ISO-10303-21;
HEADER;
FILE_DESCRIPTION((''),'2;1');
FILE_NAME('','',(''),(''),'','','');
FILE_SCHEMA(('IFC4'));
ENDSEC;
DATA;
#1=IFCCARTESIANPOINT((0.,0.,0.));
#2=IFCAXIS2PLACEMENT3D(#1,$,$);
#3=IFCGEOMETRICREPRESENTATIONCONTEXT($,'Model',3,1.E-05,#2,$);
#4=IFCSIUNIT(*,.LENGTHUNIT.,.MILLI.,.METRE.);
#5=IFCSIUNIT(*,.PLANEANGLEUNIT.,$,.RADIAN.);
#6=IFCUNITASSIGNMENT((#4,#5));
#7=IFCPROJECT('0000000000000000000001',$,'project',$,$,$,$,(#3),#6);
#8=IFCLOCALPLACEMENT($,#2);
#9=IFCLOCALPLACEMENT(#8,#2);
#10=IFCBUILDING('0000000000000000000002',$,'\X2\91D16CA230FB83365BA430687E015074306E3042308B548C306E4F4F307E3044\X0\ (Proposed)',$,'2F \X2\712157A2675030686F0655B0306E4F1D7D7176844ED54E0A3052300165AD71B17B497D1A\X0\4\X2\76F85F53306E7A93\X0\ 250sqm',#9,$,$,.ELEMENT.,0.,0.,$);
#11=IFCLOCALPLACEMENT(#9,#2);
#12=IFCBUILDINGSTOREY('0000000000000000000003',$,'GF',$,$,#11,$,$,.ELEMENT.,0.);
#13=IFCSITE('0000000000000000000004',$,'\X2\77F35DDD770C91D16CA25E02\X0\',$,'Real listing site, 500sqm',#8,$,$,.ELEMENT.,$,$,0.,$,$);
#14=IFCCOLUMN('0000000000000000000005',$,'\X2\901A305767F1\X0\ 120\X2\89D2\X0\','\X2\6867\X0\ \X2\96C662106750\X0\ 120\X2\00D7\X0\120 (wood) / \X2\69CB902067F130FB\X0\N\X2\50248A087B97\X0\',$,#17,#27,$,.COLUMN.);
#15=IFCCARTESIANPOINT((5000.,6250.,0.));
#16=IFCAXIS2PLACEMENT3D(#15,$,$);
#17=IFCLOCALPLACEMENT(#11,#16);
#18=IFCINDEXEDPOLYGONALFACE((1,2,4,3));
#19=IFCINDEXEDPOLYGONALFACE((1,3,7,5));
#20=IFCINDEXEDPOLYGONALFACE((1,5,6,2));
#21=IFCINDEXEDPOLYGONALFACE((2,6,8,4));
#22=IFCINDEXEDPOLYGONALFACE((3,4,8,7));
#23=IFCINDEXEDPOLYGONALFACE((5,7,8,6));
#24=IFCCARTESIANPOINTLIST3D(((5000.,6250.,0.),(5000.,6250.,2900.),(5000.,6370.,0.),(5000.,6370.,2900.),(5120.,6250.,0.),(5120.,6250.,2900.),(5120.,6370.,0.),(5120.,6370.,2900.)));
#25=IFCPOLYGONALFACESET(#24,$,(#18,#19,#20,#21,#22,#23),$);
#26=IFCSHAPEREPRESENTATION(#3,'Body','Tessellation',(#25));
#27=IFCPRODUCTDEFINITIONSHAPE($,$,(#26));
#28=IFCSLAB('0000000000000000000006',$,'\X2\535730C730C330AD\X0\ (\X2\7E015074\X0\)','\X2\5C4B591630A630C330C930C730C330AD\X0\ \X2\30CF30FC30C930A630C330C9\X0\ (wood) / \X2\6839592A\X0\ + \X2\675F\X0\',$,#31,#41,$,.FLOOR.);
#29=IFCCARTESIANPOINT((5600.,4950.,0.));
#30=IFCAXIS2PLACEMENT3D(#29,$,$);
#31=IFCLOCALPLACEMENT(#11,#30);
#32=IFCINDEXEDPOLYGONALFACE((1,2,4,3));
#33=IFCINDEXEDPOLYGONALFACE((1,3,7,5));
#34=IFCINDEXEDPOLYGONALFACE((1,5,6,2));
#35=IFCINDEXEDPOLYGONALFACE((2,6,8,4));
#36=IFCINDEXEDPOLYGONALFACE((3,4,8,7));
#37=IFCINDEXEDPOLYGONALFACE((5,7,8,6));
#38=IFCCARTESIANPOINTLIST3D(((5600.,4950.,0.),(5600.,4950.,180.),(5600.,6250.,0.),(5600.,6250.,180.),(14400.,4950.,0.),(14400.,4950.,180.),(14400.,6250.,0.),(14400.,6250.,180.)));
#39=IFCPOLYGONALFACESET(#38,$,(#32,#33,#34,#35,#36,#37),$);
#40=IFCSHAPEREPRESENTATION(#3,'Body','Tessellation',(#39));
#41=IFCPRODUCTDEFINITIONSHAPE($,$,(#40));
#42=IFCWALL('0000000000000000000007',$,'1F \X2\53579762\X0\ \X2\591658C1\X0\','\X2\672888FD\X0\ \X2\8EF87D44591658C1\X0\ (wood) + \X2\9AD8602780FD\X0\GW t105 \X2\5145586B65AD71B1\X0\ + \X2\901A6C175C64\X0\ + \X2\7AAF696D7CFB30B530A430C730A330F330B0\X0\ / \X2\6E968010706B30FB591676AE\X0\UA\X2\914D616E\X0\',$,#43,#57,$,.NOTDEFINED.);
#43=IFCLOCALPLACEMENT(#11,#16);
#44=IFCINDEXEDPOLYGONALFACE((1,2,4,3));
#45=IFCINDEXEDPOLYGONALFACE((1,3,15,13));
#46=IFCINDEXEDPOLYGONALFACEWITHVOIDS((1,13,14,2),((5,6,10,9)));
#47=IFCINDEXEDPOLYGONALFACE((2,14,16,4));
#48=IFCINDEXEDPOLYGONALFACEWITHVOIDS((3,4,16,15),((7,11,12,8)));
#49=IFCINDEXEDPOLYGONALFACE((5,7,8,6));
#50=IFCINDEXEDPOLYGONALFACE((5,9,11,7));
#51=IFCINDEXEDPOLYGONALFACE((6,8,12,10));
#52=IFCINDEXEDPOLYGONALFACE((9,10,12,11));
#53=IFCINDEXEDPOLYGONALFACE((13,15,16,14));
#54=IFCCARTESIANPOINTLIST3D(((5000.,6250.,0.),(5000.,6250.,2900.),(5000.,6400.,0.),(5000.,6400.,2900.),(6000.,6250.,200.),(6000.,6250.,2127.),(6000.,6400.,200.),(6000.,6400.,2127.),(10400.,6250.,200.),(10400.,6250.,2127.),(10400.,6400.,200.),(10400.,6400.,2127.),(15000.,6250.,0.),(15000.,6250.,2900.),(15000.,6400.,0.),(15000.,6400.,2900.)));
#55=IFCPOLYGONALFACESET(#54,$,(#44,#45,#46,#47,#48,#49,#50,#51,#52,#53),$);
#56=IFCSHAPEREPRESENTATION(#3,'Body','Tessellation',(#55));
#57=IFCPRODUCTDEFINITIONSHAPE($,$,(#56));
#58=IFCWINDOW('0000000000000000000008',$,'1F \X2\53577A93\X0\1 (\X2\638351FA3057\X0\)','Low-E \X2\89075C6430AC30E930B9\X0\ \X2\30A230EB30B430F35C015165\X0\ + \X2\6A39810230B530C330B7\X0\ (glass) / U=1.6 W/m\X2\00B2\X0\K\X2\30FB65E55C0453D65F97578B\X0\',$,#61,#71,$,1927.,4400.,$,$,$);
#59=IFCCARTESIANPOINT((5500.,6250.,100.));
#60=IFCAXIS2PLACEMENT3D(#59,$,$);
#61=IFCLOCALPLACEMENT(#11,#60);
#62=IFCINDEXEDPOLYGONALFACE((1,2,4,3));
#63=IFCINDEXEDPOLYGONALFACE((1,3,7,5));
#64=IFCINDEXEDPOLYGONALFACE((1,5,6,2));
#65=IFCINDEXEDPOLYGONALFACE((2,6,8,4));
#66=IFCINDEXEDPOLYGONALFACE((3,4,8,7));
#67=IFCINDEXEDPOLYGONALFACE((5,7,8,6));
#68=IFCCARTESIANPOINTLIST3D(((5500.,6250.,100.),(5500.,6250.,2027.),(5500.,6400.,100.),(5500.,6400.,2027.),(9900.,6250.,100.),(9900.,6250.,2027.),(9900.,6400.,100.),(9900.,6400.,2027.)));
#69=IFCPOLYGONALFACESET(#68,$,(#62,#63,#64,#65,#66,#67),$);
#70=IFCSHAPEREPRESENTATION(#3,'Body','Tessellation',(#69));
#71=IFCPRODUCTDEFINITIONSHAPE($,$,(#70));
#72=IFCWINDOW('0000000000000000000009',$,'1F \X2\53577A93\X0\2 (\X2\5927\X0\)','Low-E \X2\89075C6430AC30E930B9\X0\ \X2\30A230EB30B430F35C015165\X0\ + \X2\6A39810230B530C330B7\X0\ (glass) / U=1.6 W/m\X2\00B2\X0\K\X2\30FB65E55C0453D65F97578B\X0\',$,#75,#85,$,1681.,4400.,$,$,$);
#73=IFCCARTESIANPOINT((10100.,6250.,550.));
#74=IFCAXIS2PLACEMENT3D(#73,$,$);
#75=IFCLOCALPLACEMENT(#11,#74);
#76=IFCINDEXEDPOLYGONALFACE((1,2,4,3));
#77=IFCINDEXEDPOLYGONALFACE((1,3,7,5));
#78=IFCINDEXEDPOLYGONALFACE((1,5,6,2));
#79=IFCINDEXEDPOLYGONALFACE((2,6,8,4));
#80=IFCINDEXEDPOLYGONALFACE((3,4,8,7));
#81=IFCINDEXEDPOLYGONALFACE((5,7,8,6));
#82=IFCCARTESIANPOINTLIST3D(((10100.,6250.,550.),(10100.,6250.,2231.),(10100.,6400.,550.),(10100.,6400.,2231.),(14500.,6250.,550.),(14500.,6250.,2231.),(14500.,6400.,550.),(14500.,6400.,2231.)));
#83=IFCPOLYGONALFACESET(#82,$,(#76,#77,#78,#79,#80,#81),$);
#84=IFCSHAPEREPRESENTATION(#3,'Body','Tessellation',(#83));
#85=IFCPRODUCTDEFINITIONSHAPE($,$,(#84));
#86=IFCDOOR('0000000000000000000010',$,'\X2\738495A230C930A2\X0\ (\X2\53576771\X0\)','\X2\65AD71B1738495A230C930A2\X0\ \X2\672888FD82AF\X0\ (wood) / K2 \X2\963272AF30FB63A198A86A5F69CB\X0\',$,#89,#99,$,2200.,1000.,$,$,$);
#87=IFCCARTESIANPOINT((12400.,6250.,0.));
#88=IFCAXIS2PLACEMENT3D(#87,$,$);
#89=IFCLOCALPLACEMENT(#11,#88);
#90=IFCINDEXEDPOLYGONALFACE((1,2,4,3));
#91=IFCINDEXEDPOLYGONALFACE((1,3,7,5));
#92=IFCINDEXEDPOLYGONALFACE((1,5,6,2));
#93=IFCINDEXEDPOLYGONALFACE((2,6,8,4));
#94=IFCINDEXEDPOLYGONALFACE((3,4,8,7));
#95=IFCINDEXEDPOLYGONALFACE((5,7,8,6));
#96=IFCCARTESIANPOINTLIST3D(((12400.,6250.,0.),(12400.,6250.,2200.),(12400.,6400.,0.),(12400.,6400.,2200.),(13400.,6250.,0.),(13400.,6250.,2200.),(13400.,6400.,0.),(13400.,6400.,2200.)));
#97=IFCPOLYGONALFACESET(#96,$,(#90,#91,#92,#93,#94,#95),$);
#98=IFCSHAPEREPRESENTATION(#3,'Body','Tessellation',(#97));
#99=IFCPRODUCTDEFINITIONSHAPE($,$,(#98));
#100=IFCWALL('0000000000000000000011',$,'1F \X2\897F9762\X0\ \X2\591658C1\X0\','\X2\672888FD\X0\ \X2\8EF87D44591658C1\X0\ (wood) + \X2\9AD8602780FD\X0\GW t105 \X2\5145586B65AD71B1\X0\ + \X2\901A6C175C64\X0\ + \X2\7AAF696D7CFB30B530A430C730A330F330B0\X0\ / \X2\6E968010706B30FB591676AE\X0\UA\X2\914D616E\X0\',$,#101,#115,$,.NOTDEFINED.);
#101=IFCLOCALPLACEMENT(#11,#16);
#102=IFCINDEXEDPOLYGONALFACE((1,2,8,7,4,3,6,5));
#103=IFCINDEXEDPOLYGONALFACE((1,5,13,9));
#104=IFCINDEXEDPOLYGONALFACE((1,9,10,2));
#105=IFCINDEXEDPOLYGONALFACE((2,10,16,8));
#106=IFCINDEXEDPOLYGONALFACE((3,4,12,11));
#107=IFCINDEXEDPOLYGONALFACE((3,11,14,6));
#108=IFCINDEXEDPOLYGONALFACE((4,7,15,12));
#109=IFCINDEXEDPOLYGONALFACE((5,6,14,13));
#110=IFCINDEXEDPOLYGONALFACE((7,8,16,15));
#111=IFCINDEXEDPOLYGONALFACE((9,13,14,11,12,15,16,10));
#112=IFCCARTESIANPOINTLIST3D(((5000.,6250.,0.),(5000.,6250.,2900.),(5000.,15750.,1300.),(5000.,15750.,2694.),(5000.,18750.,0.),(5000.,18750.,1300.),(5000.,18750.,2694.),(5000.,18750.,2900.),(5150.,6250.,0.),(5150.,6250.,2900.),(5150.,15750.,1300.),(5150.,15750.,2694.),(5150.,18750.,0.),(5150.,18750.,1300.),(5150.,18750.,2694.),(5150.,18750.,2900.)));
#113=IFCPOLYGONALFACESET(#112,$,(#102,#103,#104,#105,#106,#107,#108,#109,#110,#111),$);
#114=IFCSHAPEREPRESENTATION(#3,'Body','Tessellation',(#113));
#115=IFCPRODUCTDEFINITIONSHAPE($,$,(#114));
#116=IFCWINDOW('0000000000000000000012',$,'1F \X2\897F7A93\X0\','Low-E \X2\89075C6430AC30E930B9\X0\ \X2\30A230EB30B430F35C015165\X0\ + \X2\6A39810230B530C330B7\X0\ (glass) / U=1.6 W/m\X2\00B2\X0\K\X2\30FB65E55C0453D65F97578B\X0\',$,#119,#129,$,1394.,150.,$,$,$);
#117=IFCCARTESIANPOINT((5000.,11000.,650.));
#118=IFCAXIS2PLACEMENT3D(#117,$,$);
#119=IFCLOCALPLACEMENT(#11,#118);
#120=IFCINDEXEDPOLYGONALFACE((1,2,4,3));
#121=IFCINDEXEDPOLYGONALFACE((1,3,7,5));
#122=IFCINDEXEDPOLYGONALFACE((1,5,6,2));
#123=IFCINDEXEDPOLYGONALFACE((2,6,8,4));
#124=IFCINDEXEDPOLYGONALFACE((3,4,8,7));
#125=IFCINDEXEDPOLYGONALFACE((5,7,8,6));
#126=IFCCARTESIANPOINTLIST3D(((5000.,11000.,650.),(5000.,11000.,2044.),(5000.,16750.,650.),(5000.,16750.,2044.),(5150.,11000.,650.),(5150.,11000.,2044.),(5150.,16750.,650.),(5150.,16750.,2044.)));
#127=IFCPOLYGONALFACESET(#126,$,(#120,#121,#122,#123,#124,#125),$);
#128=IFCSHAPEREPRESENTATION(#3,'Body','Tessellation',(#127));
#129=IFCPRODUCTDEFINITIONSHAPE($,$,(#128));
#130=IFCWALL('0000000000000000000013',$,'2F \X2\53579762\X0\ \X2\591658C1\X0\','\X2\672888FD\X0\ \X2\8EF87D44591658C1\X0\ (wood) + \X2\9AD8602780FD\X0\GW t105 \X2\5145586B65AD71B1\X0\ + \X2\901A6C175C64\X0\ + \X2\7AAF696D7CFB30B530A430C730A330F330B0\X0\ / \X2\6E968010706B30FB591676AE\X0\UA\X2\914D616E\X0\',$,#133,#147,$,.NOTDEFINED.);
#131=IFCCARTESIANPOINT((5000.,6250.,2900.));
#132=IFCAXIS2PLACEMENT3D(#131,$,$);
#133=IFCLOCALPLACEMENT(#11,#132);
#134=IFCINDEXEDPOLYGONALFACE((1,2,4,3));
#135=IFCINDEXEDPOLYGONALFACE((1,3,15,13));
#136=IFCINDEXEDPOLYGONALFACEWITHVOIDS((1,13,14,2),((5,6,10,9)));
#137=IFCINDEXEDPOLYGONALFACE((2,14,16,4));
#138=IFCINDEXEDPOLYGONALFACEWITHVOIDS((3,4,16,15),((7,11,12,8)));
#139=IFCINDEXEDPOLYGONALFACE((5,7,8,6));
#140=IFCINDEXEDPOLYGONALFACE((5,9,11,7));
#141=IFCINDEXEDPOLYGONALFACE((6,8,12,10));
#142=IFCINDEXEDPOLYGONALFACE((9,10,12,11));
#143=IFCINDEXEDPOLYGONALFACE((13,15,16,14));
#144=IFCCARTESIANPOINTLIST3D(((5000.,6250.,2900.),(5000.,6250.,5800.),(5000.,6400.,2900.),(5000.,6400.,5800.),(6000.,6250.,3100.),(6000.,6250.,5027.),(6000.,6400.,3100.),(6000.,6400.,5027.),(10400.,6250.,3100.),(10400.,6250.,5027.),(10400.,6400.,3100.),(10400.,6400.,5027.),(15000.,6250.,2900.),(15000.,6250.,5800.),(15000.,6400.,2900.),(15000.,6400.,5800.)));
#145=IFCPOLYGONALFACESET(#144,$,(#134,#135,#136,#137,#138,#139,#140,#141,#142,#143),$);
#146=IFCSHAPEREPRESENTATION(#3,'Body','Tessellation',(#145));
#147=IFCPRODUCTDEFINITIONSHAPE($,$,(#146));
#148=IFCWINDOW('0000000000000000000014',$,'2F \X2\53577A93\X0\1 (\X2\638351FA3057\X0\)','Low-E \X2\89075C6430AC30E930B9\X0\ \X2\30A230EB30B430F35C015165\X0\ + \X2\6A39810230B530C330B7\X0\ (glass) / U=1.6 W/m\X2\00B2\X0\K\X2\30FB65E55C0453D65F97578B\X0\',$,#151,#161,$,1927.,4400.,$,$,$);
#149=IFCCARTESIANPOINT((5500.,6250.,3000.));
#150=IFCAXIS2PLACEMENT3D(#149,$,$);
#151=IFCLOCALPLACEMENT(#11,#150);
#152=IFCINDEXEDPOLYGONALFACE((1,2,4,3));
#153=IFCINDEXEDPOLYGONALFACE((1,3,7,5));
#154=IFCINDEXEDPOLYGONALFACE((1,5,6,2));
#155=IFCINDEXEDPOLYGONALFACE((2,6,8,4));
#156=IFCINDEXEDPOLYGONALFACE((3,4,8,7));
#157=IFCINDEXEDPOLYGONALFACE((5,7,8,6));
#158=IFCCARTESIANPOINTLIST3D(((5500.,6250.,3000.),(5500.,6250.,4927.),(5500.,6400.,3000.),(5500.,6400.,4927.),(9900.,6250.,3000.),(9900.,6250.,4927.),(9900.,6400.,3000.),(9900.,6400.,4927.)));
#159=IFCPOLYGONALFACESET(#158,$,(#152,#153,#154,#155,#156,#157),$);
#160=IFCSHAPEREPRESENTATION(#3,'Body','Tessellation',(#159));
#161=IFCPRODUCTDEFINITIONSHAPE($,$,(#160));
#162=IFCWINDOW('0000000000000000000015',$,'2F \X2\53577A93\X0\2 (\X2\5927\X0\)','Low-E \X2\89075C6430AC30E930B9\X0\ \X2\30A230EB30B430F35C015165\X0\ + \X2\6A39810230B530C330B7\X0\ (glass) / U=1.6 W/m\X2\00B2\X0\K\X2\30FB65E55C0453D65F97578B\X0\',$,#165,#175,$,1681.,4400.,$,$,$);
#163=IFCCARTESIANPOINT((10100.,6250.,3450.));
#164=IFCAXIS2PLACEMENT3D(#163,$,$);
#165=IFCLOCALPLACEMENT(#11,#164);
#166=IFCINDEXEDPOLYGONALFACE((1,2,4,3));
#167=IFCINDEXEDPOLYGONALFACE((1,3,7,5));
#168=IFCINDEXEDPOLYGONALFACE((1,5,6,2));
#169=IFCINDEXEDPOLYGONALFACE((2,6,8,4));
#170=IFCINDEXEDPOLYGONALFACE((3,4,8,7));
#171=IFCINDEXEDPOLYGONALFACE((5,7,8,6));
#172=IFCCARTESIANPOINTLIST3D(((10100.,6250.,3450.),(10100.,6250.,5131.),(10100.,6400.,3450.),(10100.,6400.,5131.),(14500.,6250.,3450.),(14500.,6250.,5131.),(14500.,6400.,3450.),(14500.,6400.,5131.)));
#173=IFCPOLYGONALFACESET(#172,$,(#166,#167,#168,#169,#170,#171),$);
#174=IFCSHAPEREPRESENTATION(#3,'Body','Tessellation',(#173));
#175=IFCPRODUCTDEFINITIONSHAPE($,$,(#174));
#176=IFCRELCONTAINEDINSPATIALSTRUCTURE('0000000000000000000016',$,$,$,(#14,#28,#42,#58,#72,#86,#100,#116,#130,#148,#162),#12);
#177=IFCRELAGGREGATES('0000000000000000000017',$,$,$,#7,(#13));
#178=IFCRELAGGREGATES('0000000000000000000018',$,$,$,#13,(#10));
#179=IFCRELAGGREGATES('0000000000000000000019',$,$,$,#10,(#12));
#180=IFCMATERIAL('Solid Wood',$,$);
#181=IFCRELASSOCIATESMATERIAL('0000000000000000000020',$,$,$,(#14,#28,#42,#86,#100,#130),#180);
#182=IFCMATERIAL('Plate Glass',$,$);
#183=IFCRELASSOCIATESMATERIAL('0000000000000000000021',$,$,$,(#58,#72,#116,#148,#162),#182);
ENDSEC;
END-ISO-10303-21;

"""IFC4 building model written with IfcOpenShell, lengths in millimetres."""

from ifc_helpers import new_model, si_unit, frame, frame_2d, origin, place, context, project, spatial, rectangle, extrude, material, element, fill, save


model = new_model("IFC4")

# Units and contexts
model_context = context("Model", 3, precision=1e-05, world=origin())
ifc_project = project(units=[si_unit("LENGTHUNIT", "METRE", prefix="MILLI"), si_unit("PLANEANGLEUNIT", "RADIAN")], contexts=[model_context])

# Site, building, storey
site_placement = place(None, origin())
site = spatial("IfcSite", under=ifc_project, at=site_placement, Name="石川県金沢市", ObjectType="Real listing site, 500sqm", CompositionType="ELEMENT", RefElevation=0.0)
building_placement = place(site_placement, origin())
building = spatial("IfcBuilding", under=site, at=building_placement, Name="金沢・茶室と縁側のある和の住まい (Proposed)", ObjectType="2F 無垢材と漆喰の伝統的仕上げ、断熱等級4相当の窓 250sqm", CompositionType="ELEMENT", ElevationOfRefHeight=0.0, ElevationOfTerrain=0.0)
storey_placement = place(building_placement, origin())
storey = spatial("IfcBuildingStorey", under=building, at=storey_placement, Name="GF", CompositionType="ELEMENT", Elevation=0.0)

# Column
ifc_material_1 = material(Name="Solid Wood")
column_placement = place(storey_placement, frame((5000.0, 6250.0, 0.0)))
element("IfcColumn", 1, at=column_placement, inside=storey, material=ifc_material_1, Name="通し柱 120角", Description="桧 集成材 120×120 (wood) / 構造柱・N値計算", PredefinedType="COLUMN", context=model_context, shape_type="SweptSolid", body=[
    extrude(rectangle(XDim=120.0, YDim=120.0, at=frame_2d((60.0, 60.0))), frame((5000.0, 6250.0, 0.0)), (0.0, 0.0, 1.0), 2900.0),
])

# Slab
slab_1_placement = place(storey_placement, frame((5600.0, 4950.0, 0.0)))
element("IfcSlab", 2, at=slab_1_placement, inside=storey, material=ifc_material_1, Name="南デッキ (縁側)", Description="屋外ウッドデッキ ハードウッド (wood) / 根太 + 束", PredefinedType="FLOOR", context=model_context, shape_type="SweptSolid", body=[
    extrude(rectangle(XDim=8800.0, YDim=1300.0, at=frame_2d((4400.0, 650.0))), frame((5600.0, 4950.0, 0.0)), (0.0, 0.0, 1.0), 180.0),
])

# Wall, openings, windows, door
wall_1_placement = place(storey_placement, frame((5000.0, 6250.0, 0.0)))
wall_1 = element("IfcWall", 3, at=wall_1_placement, inside=storey, material=ifc_material_1, Name="1F 南面 外壁", Description="木製 軸組外壁 (wood) + 高性能GW t105 充填断熱 + 通気層 + 窯業系サイディング / 準耐火・外皮UA配慮", PredefinedType="NOTDEFINED", context=model_context, shape_type="SweptSolid", body=[
    extrude(rectangle(XDim=10000.0, YDim=150.0, at=frame_2d((5000.0, 75.0))), frame((5000.0, 6250.0, 0.0)), (0.0, 0.0, 1.0), 2900.0),
])
opening_1_placement = place(storey_placement, frame((5500.0, 6250.0, 100.0)))
opening_1 = element("IfcOpeningElement", 4, at=opening_1_placement, cuts=wall_1, PredefinedType="NOTDEFINED", context=model_context, shape_type="SweptSolid", body=[
    extrude(rectangle(XDim=4400.0, YDim=150.0, at=frame_2d((2200.0, 75.0))), frame((5500.0, 6250.0, 100.0)), (0.0, 0.0, 1.0), 1927.0),
])
opening_2_placement = place(storey_placement, frame((10100.0, 6250.0, 550.0)))
opening_2 = element("IfcOpeningElement", 5, at=opening_2_placement, cuts=wall_1, PredefinedType="NOTDEFINED", context=model_context, shape_type="SweptSolid", body=[
    extrude(rectangle(XDim=4400.0, YDim=150.0, at=frame_2d((2200.0, 75.0))), frame((10100.0, 6250.0, 550.0)), (0.0, 0.0, 1.0), 1681.0),
])
opening_3_placement = place(storey_placement, frame((12400.0, 6250.0, 0.0)))
opening_3 = element("IfcOpeningElement", 6, at=opening_3_placement, cuts=wall_1, PredefinedType="NOTDEFINED", context=model_context, shape_type="SweptSolid", body=[
    extrude(rectangle(XDim=1000.0, YDim=150.0, at=frame_2d((500.0, 75.0))), frame((12400.0, 6250.0, 0.0)), (0.0, 0.0, 1.0), 2200.0),
])
ifc_material_2 = material(Name="Plate Glass")
window_1_placement = place(storey_placement, frame((5500.0, 6250.0, 100.0)))
window_1 = element("IfcWindow", 7, at=window_1_placement, inside=storey, material=ifc_material_2, Name="1F 南窓1 (掃出し)", Description="Low-E 複層ガラス アルゴン封入 + 樹脂サッシ (glass) / U=1.6 W/m²K・日射取得型", OverallHeight=1927.0, OverallWidth=4400.0, context=model_context, shape_type="SweptSolid", body=[
    extrude(rectangle(XDim=4400.0, YDim=150.0, at=frame_2d((2200.0, 75.0))), frame((5500.0, 6250.0, 100.0)), (0.0, 0.0, 1.0), 1927.0),
])
fill(opening_1, window_1)
window_2_placement = place(storey_placement, frame((10100.0, 6250.0, 550.0)))
window_2 = element("IfcWindow", 8, at=window_2_placement, inside=storey, material=ifc_material_2, Name="1F 南窓2 (大)", Description="Low-E 複層ガラス アルゴン封入 + 樹脂サッシ (glass) / U=1.6 W/m²K・日射取得型", OverallHeight=1681.0, OverallWidth=4400.0, context=model_context, shape_type="SweptSolid", body=[
    extrude(rectangle(XDim=4400.0, YDim=150.0, at=frame_2d((2200.0, 75.0))), frame((10100.0, 6250.0, 550.0)), (0.0, 0.0, 1.0), 1681.0),
])
fill(opening_2, window_2)
door_placement = place(storey_placement, frame((12400.0, 6250.0, 0.0)))
door = element("IfcDoor", 9, at=door_placement, inside=storey, material=ifc_material_1, Name="玄関ドア (南東)", Description="断熱玄関ドア 木製芯 (wood) / K2 防犯・採風機構", OverallHeight=2200.0, OverallWidth=1000.0, context=model_context, shape_type="SweptSolid", body=[
    extrude(rectangle(XDim=1000.0, YDim=150.0, at=frame_2d((500.0, 75.0))), frame((12400.0, 6250.0, 0.0)), (0.0, 0.0, 1.0), 2200.0),
])
fill(opening_3, door)

# Wall, opening, window
wall_2_placement = place(storey_placement, frame((5000.0, 6250.0, 0.0)))
wall_2 = element("IfcWall", 10, at=wall_2_placement, inside=storey, material=ifc_material_1, Name="1F 西面 外壁", Description="木製 軸組外壁 (wood) + 高性能GW t105 充填断熱 + 通気層 + 窯業系サイディング / 準耐火・外皮UA配慮", PredefinedType="NOTDEFINED", context=model_context, shape_type="SweptSolid", body=[
    extrude(rectangle(XDim=150.0, YDim=12500.0, at=frame_2d((75.0, 6250.0))), frame((5000.0, 6250.0, 0.0)), (0.0, 0.0, 1.0), 2900.0),
])
opening_4_placement = place(storey_placement, frame((5000.0, 11000.0, 650.0)))
opening_4 = element("IfcOpeningElement", 11, at=opening_4_placement, cuts=wall_2, PredefinedType="NOTDEFINED", context=model_context, shape_type="SweptSolid", body=[
    extrude(rectangle(XDim=150.0, YDim=5750.0, at=frame_2d((75.0, 2875.0))), frame((5000.0, 11000.0, 650.0)), (0.0, 0.0, 1.0), 1394.0),
])
window_3_placement = place(storey_placement, frame((5000.0, 11000.0, 650.0)))
window_3 = element("IfcWindow", 12, at=window_3_placement, inside=storey, material=ifc_material_2, Name="1F 西窓", Description="Low-E 複層ガラス アルゴン封入 + 樹脂サッシ (glass) / U=1.6 W/m²K・日射取得型", OverallHeight=1394.0, OverallWidth=150.0, context=model_context, shape_type="SweptSolid", body=[
    extrude(rectangle(XDim=150.0, YDim=5750.0, at=frame_2d((75.0, 2875.0))), frame((5000.0, 11000.0, 650.0)), (0.0, 0.0, 1.0), 1394.0),
])
fill(opening_4, window_3)

# Wall, openings, windows
wall_3_placement = place(storey_placement, frame((5000.0, 6250.0, 2900.0)))
wall_3 = element("IfcWall", 13, at=wall_3_placement, inside=storey, material=ifc_material_1, Name="2F 南面 外壁", Description="木製 軸組外壁 (wood) + 高性能GW t105 充填断熱 + 通気層 + 窯業系サイディング / 準耐火・外皮UA配慮", PredefinedType="NOTDEFINED", context=model_context, shape_type="SweptSolid", body=[
    extrude(rectangle(XDim=10000.0, YDim=150.0, at=frame_2d((5000.0, 75.0))), frame((5000.0, 6250.0, 2900.0)), (0.0, 0.0, 1.0), 2900.0),
])
opening_5_placement = place(storey_placement, frame((5500.0, 6250.0, 3000.0)))
opening_5 = element("IfcOpeningElement", 14, at=opening_5_placement, cuts=wall_3, PredefinedType="NOTDEFINED", context=model_context, shape_type="SweptSolid", body=[
    extrude(rectangle(XDim=4400.0, YDim=150.0, at=frame_2d((2200.0, 75.0))), frame((5500.0, 6250.0, 3000.0)), (0.0, 0.0, 1.0), 1927.0),
])
opening_6_placement = place(storey_placement, frame((10100.0, 6250.0, 3450.0)))
opening_6 = element("IfcOpeningElement", 15, at=opening_6_placement, cuts=wall_3, PredefinedType="NOTDEFINED", context=model_context, shape_type="SweptSolid", body=[
    extrude(rectangle(XDim=4400.0, YDim=150.0, at=frame_2d((2200.0, 75.0))), frame((10100.0, 6250.0, 3450.0)), (0.0, 0.0, 1.0), 1681.0),
])
window_4_placement = place(storey_placement, frame((5500.0, 6250.0, 3000.0)))
window_4 = element("IfcWindow", 16, at=window_4_placement, inside=storey, material=ifc_material_2, Name="2F 南窓1 (掃出し)", Description="Low-E 複層ガラス アルゴン封入 + 樹脂サッシ (glass) / U=1.6 W/m²K・日射取得型", OverallHeight=1927.0, OverallWidth=4400.0, context=model_context, shape_type="SweptSolid", body=[
    extrude(rectangle(XDim=4400.0, YDim=150.0, at=frame_2d((2200.0, 75.0))), frame((5500.0, 6250.0, 3000.0)), (0.0, 0.0, 1.0), 1927.0),
])
fill(opening_5, window_4)
window_5_placement = place(storey_placement, frame((10100.0, 6250.0, 3450.0)))
window_5 = element("IfcWindow", 17, at=window_5_placement, inside=storey, material=ifc_material_2, Name="2F 南窓2 (大)", Description="Low-E 複層ガラス アルゴン封入 + 樹脂サッシ (glass) / U=1.6 W/m²K・日射取得型", OverallHeight=1681.0, OverallWidth=4400.0, context=model_context, shape_type="SweptSolid", body=[
    extrude(rectangle(XDim=4400.0, YDim=150.0, at=frame_2d((2200.0, 75.0))), frame((10100.0, 6250.0, 3450.0)), (0.0, 0.0, 1.0), 1681.0),
])
fill(opening_6, window_5)

save(model, "model.ifc")
